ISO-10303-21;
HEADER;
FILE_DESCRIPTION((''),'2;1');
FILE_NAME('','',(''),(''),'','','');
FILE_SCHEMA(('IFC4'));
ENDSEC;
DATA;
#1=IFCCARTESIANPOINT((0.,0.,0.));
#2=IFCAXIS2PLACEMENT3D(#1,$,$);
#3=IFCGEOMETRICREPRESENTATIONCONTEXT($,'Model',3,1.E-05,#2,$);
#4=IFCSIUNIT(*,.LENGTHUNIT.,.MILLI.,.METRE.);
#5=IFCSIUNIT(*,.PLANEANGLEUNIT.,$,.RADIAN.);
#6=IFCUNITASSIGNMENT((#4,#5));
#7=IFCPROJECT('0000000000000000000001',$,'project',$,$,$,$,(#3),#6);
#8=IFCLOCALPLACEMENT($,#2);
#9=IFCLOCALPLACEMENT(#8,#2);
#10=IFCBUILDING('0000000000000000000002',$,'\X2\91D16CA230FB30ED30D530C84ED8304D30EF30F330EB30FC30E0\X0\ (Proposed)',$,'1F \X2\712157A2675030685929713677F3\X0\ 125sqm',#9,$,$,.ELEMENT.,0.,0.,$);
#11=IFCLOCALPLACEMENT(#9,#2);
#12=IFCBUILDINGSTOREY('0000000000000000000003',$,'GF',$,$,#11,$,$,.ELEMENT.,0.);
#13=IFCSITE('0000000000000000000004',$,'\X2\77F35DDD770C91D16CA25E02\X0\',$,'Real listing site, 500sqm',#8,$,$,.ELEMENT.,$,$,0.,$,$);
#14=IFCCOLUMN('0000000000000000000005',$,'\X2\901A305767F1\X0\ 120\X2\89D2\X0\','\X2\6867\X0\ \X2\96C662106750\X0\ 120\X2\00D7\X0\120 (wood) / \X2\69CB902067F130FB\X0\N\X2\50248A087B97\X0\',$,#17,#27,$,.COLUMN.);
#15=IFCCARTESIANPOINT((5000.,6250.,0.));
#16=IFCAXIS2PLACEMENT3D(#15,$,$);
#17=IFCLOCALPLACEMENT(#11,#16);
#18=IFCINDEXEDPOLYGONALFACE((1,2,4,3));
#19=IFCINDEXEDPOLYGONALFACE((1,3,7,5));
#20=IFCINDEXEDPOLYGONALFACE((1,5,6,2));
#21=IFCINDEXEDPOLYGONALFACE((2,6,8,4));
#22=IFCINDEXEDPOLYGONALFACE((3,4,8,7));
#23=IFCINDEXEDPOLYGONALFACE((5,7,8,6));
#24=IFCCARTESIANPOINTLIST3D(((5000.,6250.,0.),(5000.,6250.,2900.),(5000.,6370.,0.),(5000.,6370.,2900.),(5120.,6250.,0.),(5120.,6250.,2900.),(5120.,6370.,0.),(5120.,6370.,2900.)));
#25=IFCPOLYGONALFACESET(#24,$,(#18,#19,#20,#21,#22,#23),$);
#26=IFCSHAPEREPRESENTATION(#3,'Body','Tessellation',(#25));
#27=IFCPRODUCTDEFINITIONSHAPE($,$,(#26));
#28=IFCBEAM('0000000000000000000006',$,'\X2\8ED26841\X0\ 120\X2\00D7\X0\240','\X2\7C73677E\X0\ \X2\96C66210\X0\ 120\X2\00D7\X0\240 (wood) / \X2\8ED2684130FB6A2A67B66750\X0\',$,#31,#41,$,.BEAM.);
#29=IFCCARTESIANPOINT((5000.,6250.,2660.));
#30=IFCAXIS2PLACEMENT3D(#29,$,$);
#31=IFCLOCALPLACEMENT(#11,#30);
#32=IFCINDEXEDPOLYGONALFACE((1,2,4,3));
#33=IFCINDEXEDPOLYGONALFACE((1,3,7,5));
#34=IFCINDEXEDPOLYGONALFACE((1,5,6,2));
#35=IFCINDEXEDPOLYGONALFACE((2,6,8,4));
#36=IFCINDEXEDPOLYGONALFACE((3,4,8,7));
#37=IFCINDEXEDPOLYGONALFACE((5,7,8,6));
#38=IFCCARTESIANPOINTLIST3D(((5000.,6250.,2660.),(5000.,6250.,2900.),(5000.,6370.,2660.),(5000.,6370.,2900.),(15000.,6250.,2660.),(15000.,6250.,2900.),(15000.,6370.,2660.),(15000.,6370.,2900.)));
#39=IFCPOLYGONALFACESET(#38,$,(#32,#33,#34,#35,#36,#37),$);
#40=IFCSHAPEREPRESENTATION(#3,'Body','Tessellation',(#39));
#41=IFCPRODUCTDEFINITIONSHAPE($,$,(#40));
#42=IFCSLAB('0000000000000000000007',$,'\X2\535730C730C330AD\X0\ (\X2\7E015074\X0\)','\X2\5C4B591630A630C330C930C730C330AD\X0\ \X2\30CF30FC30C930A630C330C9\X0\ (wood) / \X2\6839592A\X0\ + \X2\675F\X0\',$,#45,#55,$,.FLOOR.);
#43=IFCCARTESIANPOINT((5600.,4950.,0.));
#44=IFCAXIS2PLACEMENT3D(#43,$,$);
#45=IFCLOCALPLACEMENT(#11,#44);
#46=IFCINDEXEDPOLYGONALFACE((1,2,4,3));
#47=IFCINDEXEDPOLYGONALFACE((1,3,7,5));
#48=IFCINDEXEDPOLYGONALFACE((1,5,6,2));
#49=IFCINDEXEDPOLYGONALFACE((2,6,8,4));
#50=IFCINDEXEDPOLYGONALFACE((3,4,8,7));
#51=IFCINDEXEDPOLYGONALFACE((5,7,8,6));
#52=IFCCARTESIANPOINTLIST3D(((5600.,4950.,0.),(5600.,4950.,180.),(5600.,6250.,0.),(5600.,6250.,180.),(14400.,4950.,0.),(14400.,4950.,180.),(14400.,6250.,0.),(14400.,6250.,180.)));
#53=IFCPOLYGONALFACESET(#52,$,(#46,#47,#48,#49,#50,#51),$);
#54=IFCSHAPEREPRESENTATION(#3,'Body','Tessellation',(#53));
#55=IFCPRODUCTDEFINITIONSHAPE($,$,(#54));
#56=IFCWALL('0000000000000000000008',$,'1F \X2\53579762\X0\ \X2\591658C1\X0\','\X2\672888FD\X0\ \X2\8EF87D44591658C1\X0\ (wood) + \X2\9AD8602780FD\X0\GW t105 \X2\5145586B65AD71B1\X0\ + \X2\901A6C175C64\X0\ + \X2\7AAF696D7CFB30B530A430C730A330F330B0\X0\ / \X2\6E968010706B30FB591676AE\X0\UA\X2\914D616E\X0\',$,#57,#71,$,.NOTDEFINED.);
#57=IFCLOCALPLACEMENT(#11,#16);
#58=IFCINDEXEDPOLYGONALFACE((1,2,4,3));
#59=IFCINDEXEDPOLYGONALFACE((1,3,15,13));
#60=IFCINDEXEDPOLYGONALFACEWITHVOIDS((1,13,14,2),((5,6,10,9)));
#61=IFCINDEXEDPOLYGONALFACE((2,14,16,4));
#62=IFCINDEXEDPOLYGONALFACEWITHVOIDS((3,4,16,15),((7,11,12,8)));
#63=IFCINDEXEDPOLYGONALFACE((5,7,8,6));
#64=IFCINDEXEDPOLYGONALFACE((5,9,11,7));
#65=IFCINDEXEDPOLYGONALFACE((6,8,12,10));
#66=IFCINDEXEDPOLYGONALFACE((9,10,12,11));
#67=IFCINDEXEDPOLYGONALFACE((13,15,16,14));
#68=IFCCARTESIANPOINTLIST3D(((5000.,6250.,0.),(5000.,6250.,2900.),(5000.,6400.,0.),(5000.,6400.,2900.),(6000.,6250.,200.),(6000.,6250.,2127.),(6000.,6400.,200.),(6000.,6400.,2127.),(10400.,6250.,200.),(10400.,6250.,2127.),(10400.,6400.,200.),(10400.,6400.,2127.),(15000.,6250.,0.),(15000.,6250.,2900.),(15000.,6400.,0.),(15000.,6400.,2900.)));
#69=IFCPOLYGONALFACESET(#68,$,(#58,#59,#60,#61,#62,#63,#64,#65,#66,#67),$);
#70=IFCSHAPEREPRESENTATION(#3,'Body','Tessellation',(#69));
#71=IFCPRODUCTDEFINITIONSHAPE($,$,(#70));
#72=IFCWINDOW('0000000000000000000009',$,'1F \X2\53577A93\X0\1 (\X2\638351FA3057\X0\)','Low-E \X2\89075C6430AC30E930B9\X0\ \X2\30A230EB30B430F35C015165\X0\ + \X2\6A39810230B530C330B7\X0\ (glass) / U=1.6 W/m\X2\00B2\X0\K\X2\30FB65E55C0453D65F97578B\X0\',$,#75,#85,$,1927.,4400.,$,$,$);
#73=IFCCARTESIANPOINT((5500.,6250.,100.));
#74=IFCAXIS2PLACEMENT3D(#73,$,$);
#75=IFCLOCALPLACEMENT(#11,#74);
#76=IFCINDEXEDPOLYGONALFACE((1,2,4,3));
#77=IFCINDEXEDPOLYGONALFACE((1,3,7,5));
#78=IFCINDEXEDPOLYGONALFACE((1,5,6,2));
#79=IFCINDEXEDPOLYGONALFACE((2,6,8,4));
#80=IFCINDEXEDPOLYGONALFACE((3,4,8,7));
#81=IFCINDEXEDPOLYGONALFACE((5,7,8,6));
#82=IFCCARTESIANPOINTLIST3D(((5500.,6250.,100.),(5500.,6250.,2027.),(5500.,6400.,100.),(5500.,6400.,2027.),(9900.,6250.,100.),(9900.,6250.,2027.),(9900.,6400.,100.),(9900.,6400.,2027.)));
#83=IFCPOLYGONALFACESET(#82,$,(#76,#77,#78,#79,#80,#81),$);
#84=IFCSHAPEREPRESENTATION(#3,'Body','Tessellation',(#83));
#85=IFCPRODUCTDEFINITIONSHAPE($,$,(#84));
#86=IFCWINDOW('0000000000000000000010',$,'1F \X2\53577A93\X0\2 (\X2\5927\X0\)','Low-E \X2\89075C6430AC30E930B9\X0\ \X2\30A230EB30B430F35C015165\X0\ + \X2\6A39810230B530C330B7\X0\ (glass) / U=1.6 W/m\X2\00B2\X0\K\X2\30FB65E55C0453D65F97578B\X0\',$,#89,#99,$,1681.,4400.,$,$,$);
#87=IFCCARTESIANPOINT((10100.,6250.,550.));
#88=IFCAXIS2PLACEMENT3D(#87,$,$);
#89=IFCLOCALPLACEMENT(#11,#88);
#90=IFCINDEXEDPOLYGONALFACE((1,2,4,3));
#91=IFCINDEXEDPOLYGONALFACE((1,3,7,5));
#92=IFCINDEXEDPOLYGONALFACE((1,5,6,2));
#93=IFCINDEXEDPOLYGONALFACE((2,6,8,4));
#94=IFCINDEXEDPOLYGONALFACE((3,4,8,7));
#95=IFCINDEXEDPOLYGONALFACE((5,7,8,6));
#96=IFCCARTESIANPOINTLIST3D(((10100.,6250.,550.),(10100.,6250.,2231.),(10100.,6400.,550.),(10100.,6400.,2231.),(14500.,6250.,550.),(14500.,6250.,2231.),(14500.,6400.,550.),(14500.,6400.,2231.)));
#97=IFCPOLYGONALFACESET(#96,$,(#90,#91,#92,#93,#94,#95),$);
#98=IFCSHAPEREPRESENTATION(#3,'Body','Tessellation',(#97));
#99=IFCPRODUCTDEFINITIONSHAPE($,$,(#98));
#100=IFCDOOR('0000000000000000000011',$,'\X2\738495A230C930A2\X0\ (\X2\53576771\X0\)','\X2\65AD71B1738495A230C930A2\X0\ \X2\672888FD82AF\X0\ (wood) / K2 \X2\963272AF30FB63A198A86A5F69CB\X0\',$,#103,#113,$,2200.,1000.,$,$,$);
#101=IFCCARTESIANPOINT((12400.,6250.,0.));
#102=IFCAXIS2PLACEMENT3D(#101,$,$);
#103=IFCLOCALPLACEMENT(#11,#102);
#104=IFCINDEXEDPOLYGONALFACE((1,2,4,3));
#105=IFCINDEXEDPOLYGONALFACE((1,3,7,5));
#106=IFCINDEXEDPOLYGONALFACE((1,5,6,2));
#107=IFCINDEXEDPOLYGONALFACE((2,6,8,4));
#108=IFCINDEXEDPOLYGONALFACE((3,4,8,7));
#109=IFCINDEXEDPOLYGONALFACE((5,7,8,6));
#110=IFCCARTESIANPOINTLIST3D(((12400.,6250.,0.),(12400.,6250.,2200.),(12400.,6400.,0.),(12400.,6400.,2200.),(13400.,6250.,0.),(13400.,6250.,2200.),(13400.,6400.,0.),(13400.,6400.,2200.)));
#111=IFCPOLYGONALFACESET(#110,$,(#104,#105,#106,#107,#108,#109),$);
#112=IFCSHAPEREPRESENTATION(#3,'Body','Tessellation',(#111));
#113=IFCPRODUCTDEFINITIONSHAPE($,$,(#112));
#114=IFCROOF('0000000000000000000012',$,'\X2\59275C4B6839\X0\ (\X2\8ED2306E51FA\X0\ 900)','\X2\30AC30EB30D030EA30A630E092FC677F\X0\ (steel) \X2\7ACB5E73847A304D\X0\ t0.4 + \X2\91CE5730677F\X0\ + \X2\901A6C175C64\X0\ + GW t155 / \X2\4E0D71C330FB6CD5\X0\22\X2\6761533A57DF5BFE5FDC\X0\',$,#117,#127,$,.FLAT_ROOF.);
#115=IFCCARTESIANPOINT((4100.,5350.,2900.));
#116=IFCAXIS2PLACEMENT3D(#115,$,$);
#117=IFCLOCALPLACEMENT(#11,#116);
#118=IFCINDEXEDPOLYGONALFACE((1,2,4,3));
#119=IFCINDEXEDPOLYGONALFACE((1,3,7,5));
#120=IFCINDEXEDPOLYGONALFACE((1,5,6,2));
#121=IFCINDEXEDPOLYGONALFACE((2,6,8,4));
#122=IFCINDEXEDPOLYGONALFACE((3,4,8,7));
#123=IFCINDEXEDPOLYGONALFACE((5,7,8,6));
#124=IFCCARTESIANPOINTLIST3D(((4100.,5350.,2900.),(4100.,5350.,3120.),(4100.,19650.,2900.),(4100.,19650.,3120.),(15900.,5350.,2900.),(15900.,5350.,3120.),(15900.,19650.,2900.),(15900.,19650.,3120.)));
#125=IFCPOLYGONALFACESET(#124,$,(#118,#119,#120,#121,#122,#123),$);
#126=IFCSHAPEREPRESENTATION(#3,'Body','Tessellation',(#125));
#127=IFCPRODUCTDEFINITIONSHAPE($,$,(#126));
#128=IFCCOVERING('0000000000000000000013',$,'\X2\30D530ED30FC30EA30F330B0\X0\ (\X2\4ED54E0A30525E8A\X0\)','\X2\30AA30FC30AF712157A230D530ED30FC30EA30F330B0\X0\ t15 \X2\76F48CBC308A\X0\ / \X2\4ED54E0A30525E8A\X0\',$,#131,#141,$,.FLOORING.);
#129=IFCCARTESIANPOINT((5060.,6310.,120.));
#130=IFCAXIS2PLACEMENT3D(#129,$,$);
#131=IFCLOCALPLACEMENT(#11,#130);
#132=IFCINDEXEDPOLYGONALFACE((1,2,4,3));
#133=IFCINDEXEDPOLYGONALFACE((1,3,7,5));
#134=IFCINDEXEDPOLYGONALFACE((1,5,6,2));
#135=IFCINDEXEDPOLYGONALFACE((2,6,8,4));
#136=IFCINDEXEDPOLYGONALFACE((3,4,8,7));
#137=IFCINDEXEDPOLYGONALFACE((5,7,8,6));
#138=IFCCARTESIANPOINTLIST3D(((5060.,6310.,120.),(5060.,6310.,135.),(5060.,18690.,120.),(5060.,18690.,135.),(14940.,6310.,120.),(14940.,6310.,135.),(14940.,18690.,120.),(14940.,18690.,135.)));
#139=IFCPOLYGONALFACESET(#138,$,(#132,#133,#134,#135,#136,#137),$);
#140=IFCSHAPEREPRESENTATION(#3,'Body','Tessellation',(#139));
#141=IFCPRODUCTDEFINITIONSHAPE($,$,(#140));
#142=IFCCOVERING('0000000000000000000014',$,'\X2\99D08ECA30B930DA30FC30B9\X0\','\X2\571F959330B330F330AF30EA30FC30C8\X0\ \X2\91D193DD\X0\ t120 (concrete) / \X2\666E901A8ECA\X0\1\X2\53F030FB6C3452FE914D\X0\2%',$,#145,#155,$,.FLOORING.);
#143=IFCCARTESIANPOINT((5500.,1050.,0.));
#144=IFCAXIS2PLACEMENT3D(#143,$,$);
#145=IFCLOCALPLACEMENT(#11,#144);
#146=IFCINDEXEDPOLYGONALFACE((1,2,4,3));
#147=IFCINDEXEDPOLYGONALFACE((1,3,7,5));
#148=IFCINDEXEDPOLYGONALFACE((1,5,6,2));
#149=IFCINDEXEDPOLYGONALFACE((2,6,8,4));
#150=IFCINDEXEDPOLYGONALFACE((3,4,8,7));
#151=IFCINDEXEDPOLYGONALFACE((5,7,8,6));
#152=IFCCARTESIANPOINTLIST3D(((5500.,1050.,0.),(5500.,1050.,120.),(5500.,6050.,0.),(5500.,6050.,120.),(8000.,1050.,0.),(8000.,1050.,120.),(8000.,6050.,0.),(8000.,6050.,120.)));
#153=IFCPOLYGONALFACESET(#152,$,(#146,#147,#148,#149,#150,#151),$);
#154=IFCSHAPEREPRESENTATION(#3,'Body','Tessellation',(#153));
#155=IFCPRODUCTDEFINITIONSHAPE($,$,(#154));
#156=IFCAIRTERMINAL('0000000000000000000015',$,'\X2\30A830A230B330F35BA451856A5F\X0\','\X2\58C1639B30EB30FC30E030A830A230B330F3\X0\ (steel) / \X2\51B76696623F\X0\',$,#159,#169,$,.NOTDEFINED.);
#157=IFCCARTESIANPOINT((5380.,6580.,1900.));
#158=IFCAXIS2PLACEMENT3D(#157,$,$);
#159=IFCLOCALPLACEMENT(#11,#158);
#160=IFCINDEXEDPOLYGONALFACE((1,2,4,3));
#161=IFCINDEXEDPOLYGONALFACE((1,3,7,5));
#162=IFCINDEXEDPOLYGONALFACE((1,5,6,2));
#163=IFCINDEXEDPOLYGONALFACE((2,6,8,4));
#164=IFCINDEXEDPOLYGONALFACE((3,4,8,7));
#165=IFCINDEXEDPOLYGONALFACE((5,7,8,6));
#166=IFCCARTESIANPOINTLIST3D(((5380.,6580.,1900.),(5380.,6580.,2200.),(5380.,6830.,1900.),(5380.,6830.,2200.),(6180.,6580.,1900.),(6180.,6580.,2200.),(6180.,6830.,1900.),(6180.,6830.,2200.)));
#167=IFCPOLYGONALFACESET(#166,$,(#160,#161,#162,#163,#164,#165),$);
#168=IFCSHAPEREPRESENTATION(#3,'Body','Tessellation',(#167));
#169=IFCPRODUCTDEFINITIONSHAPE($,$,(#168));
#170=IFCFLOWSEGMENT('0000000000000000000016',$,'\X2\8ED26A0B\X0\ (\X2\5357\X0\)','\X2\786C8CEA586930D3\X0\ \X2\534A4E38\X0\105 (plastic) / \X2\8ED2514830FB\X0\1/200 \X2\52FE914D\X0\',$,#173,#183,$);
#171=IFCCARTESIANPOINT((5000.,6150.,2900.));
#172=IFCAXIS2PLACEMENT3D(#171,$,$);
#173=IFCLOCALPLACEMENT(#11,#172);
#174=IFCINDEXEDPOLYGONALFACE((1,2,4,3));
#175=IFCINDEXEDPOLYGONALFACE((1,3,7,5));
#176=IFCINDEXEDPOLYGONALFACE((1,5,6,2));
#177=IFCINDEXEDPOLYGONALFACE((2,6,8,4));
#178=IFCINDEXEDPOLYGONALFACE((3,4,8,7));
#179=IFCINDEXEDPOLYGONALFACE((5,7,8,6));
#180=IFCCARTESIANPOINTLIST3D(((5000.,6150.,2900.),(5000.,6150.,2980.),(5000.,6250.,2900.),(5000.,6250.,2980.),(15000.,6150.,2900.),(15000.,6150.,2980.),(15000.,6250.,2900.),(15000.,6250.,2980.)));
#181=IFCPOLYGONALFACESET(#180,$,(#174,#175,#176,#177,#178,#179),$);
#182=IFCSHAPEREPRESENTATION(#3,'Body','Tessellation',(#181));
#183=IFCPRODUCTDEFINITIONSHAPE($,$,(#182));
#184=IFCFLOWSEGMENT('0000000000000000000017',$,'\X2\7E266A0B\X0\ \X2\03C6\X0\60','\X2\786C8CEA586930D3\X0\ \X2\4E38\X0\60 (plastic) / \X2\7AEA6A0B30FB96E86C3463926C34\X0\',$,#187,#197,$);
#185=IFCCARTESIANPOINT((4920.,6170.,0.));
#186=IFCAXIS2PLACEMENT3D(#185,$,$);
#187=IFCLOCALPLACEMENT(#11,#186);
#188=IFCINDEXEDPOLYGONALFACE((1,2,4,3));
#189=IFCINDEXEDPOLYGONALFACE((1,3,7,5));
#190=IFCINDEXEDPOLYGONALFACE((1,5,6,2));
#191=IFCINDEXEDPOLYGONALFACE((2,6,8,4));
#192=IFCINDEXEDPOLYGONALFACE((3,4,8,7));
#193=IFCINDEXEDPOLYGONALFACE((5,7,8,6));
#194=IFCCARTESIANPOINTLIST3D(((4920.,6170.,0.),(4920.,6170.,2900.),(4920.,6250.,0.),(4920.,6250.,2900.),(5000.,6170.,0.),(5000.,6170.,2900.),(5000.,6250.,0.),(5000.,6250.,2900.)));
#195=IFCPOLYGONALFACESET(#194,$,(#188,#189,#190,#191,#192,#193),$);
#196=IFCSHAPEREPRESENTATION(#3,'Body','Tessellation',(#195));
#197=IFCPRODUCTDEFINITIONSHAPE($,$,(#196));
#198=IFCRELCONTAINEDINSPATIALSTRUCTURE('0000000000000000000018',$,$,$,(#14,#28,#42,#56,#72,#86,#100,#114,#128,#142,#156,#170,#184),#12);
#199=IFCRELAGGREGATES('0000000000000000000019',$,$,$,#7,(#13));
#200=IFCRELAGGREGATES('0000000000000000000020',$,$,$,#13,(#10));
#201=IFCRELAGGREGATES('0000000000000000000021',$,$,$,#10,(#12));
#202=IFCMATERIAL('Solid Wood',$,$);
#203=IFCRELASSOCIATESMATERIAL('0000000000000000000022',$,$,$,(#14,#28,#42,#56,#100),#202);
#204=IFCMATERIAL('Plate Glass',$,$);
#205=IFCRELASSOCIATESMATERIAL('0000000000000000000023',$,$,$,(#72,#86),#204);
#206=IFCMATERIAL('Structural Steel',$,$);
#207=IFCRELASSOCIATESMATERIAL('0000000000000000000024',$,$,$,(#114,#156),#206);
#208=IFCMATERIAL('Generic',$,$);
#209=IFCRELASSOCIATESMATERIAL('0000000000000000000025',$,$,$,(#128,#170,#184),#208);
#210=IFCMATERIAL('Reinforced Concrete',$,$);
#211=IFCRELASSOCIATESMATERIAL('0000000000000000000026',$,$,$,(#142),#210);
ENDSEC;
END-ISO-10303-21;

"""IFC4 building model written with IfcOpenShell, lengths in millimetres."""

from ifc_helpers import new_model, si_unit, frame, frame_2d, origin, place, context, project, spatial, rectangle, extrude, material, element, fill, save


model = new_model("IFC4")

# Units and contexts
model_context = context("Model", 3, precision=1e-05, world=origin())
ifc_project = project(units=[si_unit("LENGTHUNIT", "METRE", prefix="MILLI"), si_unit("PLANEANGLEUNIT", "RADIAN")], contexts=[model_context])

# Site, building, storey
site_placement = place(None, origin())
site = spatial("IfcSite", under=ifc_project, at=site_placement, Name="石川県金沢市", ObjectType="Real listing site, 500sqm", CompositionType="ELEMENT", RefElevation=0.0)
building_placement = place(site_placement, origin())
building = spatial("IfcBuilding", under=site, at=building_placement, Name="金沢・ロフト付きワンルーム (Proposed)", ObjectType="1F 無垢材と天然石 125sqm", CompositionType="ELEMENT", ElevationOfRefHeight=0.0, ElevationOfTerrain=0.0)
storey_placement = place(building_placement, origin())
storey = spatial("IfcBuildingStorey", under=building, at=storey_placement, Name="GF", CompositionType="ELEMENT", Elevation=0.0)

# Column
ifc_material_1 = material(Name="Solid Wood")
column_1_placement = place(storey_placement, frame((5000.0, 6250.0, 0.0)))
element("IfcColumn", 1, at=column_1_placement, inside=storey, material=ifc_material_1, Name="通し柱 120角", Description="桧 集成材 120×120 (wood) / 構造柱・N値計算", PredefinedType="COLUMN", context=model_context, shape_type="SweptSolid", body=[
    extrude(rectangle(XDim=120.0, YDim=120.0, at=frame_2d((60.0, 60.0))), frame((5000.0, 6250.0, 0.0)), (0.0, 0.0, 1.0), 2900.0),
])

# Beam
beam_1_placement = place(storey_placement, frame((5000.0, 6250.0, 2660.0)))
element("IfcBeam", 2, at=beam_1_placement, inside=storey, material=ifc_material_1, Name="軒桁 120×240", Description="米松 集成 120×240 (wood) / 軒桁・横架材", PredefinedType="BEAM", context=model_context, shape_type="SweptSolid", body=[
    extrude(rectangle(XDim=10000.0, YDim=120.0, at=frame_2d((5000.0, 60.0))), frame((5000.0, 6250.0, 2660.0)), (0.0, 0.0, 1.0), 240.0),
])

# Slab
ifc_material_2 = material(Name="Reinforced Concrete")
slab_1_placement = place(storey_placement, frame((5600.0, 4950.0, 0.0)))
element("IfcSlab", 3, at=slab_1_placement, inside=storey, material=ifc_material_1, Name="南デッキ (縁側)", Description="屋外ウッドデッキ ハードウッド (wood) / 根太 + 束", PredefinedType="FLOOR", context=model_context, shape_type="SweptSolid", body=[
    extrude(rectangle(XDim=8800.0, YDim=1300.0, at=frame_2d((4400.0, 650.0))), frame((5600.0, 4950.0, 0.0)), (0.0, 0.0, 1.0), 180.0),
])

# Wall, openings, windows, door
wall_1_placement = place(storey_placement, frame((5000.0, 6250.0, 0.0)))
wall_1 = element("IfcWall", 4, at=wall_1_placement, inside=storey, material=ifc_material_1, Name="1F 南面 外壁", Description="木製 軸組外壁 (wood) + 高性能GW t105 充填断熱 + 通気層 + 窯業系サイディング / 準耐火・外皮UA配慮", PredefinedType="NOTDEFINED", context=model_context, shape_type="SweptSolid", body=[
    extrude(rectangle(XDim=10000.0, YDim=150.0, at=frame_2d((5000.0, 75.0))), frame((5000.0, 6250.0, 0.0)), (0.0, 0.0, 1.0), 2900.0),
])
opening_1_placement = place(storey_placement, frame((5500.0, 6250.0, 100.0)))
opening_1 = element("IfcOpeningElement", 5, at=opening_1_placement, cuts=wall_1, PredefinedType="NOTDEFINED", context=model_context, shape_type="SweptSolid", body=[
    extrude(rectangle(XDim=4400.0, YDim=150.0, at=frame_2d((2200.0, 75.0))), frame((5500.0, 6250.0, 100.0)), (0.0, 0.0, 1.0), 1927.0),
])
opening_2_placement = place(storey_placement, frame((10100.0, 6250.0, 550.0)))
opening_2 = element("IfcOpeningElement", 6, at=opening_2_placement, cuts=wall_1, PredefinedType="NOTDEFINED", context=model_context, shape_type="SweptSolid", body=[
    extrude(rectangle(XDim=4400.0, YDim=150.0, at=frame_2d((2200.0, 75.0))), frame((10100.0, 6250.0, 550.0)), (0.0, 0.0, 1.0), 1681.0),
])
opening_3_placement = place(storey_placement, frame((12400.0, 6250.0, 0.0)))
opening_3 = element("IfcOpeningElement", 7, at=opening_3_placement, cuts=wall_1, PredefinedType="NOTDEFINED", context=model_context, shape_type="SweptSolid", body=[
    extrude(rectangle(XDim=1000.0, YDim=150.0, at=frame_2d((500.0, 75.0))), frame((12400.0, 6250.0, 0.0)), (0.0, 0.0, 1.0), 2200.0),
])
ifc_material_3 = material(Name="Plate Glass")
window_1_placement = place(storey_placement, frame((5500.0, 6250.0, 100.0)))
window_1 = element("IfcWindow", 8, at=window_1_placement, inside=storey, material=ifc_material_3, Name="1F 南窓1 (掃出し)", Description="Low-E 複層ガラス アルゴン封入 + 樹脂サッシ (glass) / U=1.6 W/m²K・日射取得型", OverallHeight=1927.0, OverallWidth=4400.0, context=model_context, shape_type="SweptSolid", body=[
    extrude(rectangle(XDim=4400.0, YDim=150.0, at=frame_2d((2200.0, 75.0))), frame((5500.0, 6250.0, 100.0)), (0.0, 0.0, 1.0), 1927.0),
])
fill(opening_1, window_1)
window_2_placement = place(storey_placement, frame((10100.0, 6250.0, 550.0)))
window_2 = element("IfcWindow", 9, at=window_2_placement, inside=storey, material=ifc_material_3, Name="1F 南窓2 (大)", Description="Low-E 複層ガラス アルゴン封入 + 樹脂サッシ (glass) / U=1.6 W/m²K・日射取得型", OverallHeight=1681.0, OverallWidth=4400.0, context=model_context, shape_type="SweptSolid", body=[
    extrude(rectangle(XDim=4400.0, YDim=150.0, at=frame_2d((2200.0, 75.0))), frame((10100.0, 6250.0, 550.0)), (0.0, 0.0, 1.0), 1681.0),
])
fill(opening_2, window_2)
door_placement = place(storey_placement, frame((12400.0, 6250.0, 0.0)))
door = element("IfcDoor", 10, at=door_placement, inside=storey, material=ifc_material_1, Name="玄関ドア (南東)", Description="断熱玄関ドア 木製芯 (wood) / K2 防犯・採風機構", OverallHeight=2200.0, OverallWidth=1000.0, context=model_context, shape_type="SweptSolid", body=[
    extrude(rectangle(XDim=1000.0, YDim=150.0, at=frame_2d((500.0, 75.0))), frame((12400.0, 6250.0, 0.0)), (0.0, 0.0, 1.0), 2200.0),
])
fill(opening_3, door)

# Roof
ifc_material_4 = material(Name="Structural Steel")
roof_placement = place(storey_placement, frame((4100.0, 5350.0, 2900.0)))
element("IfcRoof", 11, at=roof_placement, inside=storey, material=ifc_material_4, Name="大屋根 (軒の出 900)", Description="ガルバリウム鋼板 (steel) 立平葺き t0.4 + 野地板 + 通気層 + GW t155 / 不燃・法22条区域対応", PredefinedType="FLAT_ROOF", context=model_context, shape_type="SweptSolid", body=[
    extrude(rectangle(XDim=11800.0, YDim=14300.0, at=frame_2d((5900.0, 7150.0))), frame((4100.0, 5350.0, 2900.0)), (0.0, 0.0, 1.0), 220.0),
])

# Coverings
ifc_material_5 = material(Name="Generic")
covering_1_placement = place(storey_placement, frame((5060.0, 6310.0, 120.0)))
element("IfcCovering", 12, at=covering_1_placement, inside=storey, material=ifc_material_5, Name="フローリング (仕上げ床)", Description="オーク無垢フローリング t15 直貼り / 仕上げ床", PredefinedType="FLOORING", context=model_context, shape_type="SweptSolid", body=[
    extrude(rectangle(XDim=9880.0, YDim=12380.0, at=frame_2d((4940.0, 6190.0))), frame((5060.0, 6310.0, 120.0)), (0.0, 0.0, 1.0), 15.0),
])
covering_2_placement = place(storey_placement, frame((5500.0, 1050.0, 0.0)))
element("IfcCovering", 13, at=covering_2_placement, inside=storey, material=ifc_material_2, Name="駐車スペース", Description="土間コンクリート 金鏝 t120 (concrete) / 普通車1台・水勾配2%", PredefinedType="FLOORING", context=model_context, shape_type="SweptSolid", body=[
    extrude(rectangle(XDim=2500.0, YDim=5000.0, at=frame_2d((1250.0, 2500.0))), frame((5500.0, 1050.0, 0.0)), (0.0, 0.0, 1.0), 120.0),
])

# Air terminal
air_terminal_placement = place(storey_placement, frame((5380.0, 6580.0, 1900.0)))
element("IfcAirTerminal", 14, at=air_terminal_placement, inside=storey, material=ifc_material_4, Name="エアコン室内機", Description="壁掛ルームエアコン (steel) / 冷暖房", PredefinedType="NOTDEFINED", context=model_context, shape_type="SweptSolid", body=[
    extrude(rectangle(XDim=800.0, YDim=250.0, at=frame_2d((400.0, 125.0))), frame((5380.0, 6580.0, 1900.0)), (0.0, 0.0, 1.0), 300.0),
])

# Flow segments
flow_segment_1_placement = place(storey_placement, frame((5000.0, 6150.0, 2900.0)))
element("IfcFlowSegment", 15, at=flow_segment_1_placement, inside=storey, material=ifc_material_5, Name="軒樋 (南)", Description="硬質塩ビ 半丸105 (plastic) / 軒先・1/200 勾配", context=model_context, shape_type="SweptSolid", body=[
    extrude(rectangle(XDim=10000.0, YDim=100.0, at=frame_2d((5000.0, 50.0))), frame((5000.0, 6150.0, 2900.0)), (0.0, 0.0, 1.0), 80.0),
])
flow_segment_2_placement = place(storey_placement, frame((4920.0, 6170.0, 0.0)))
element("IfcFlowSegment", 16, at=flow_segment_2_placement, inside=storey, material=ifc_material_5, Name="縦樋 φ60", Description="硬質塩ビ 丸60 (plastic) / 竪樋・雨水排水", context=model_context, shape_type="SweptSolid", body=[
    extrude(rectangle(XDim=80.0, YDim=80.0, at=frame_2d((40.0, 40.0))), frame((4920.0, 6170.0, 0.0)), (0.0, 0.0, 1.0), 2900.0),
])

save(model, "model.ifc")
